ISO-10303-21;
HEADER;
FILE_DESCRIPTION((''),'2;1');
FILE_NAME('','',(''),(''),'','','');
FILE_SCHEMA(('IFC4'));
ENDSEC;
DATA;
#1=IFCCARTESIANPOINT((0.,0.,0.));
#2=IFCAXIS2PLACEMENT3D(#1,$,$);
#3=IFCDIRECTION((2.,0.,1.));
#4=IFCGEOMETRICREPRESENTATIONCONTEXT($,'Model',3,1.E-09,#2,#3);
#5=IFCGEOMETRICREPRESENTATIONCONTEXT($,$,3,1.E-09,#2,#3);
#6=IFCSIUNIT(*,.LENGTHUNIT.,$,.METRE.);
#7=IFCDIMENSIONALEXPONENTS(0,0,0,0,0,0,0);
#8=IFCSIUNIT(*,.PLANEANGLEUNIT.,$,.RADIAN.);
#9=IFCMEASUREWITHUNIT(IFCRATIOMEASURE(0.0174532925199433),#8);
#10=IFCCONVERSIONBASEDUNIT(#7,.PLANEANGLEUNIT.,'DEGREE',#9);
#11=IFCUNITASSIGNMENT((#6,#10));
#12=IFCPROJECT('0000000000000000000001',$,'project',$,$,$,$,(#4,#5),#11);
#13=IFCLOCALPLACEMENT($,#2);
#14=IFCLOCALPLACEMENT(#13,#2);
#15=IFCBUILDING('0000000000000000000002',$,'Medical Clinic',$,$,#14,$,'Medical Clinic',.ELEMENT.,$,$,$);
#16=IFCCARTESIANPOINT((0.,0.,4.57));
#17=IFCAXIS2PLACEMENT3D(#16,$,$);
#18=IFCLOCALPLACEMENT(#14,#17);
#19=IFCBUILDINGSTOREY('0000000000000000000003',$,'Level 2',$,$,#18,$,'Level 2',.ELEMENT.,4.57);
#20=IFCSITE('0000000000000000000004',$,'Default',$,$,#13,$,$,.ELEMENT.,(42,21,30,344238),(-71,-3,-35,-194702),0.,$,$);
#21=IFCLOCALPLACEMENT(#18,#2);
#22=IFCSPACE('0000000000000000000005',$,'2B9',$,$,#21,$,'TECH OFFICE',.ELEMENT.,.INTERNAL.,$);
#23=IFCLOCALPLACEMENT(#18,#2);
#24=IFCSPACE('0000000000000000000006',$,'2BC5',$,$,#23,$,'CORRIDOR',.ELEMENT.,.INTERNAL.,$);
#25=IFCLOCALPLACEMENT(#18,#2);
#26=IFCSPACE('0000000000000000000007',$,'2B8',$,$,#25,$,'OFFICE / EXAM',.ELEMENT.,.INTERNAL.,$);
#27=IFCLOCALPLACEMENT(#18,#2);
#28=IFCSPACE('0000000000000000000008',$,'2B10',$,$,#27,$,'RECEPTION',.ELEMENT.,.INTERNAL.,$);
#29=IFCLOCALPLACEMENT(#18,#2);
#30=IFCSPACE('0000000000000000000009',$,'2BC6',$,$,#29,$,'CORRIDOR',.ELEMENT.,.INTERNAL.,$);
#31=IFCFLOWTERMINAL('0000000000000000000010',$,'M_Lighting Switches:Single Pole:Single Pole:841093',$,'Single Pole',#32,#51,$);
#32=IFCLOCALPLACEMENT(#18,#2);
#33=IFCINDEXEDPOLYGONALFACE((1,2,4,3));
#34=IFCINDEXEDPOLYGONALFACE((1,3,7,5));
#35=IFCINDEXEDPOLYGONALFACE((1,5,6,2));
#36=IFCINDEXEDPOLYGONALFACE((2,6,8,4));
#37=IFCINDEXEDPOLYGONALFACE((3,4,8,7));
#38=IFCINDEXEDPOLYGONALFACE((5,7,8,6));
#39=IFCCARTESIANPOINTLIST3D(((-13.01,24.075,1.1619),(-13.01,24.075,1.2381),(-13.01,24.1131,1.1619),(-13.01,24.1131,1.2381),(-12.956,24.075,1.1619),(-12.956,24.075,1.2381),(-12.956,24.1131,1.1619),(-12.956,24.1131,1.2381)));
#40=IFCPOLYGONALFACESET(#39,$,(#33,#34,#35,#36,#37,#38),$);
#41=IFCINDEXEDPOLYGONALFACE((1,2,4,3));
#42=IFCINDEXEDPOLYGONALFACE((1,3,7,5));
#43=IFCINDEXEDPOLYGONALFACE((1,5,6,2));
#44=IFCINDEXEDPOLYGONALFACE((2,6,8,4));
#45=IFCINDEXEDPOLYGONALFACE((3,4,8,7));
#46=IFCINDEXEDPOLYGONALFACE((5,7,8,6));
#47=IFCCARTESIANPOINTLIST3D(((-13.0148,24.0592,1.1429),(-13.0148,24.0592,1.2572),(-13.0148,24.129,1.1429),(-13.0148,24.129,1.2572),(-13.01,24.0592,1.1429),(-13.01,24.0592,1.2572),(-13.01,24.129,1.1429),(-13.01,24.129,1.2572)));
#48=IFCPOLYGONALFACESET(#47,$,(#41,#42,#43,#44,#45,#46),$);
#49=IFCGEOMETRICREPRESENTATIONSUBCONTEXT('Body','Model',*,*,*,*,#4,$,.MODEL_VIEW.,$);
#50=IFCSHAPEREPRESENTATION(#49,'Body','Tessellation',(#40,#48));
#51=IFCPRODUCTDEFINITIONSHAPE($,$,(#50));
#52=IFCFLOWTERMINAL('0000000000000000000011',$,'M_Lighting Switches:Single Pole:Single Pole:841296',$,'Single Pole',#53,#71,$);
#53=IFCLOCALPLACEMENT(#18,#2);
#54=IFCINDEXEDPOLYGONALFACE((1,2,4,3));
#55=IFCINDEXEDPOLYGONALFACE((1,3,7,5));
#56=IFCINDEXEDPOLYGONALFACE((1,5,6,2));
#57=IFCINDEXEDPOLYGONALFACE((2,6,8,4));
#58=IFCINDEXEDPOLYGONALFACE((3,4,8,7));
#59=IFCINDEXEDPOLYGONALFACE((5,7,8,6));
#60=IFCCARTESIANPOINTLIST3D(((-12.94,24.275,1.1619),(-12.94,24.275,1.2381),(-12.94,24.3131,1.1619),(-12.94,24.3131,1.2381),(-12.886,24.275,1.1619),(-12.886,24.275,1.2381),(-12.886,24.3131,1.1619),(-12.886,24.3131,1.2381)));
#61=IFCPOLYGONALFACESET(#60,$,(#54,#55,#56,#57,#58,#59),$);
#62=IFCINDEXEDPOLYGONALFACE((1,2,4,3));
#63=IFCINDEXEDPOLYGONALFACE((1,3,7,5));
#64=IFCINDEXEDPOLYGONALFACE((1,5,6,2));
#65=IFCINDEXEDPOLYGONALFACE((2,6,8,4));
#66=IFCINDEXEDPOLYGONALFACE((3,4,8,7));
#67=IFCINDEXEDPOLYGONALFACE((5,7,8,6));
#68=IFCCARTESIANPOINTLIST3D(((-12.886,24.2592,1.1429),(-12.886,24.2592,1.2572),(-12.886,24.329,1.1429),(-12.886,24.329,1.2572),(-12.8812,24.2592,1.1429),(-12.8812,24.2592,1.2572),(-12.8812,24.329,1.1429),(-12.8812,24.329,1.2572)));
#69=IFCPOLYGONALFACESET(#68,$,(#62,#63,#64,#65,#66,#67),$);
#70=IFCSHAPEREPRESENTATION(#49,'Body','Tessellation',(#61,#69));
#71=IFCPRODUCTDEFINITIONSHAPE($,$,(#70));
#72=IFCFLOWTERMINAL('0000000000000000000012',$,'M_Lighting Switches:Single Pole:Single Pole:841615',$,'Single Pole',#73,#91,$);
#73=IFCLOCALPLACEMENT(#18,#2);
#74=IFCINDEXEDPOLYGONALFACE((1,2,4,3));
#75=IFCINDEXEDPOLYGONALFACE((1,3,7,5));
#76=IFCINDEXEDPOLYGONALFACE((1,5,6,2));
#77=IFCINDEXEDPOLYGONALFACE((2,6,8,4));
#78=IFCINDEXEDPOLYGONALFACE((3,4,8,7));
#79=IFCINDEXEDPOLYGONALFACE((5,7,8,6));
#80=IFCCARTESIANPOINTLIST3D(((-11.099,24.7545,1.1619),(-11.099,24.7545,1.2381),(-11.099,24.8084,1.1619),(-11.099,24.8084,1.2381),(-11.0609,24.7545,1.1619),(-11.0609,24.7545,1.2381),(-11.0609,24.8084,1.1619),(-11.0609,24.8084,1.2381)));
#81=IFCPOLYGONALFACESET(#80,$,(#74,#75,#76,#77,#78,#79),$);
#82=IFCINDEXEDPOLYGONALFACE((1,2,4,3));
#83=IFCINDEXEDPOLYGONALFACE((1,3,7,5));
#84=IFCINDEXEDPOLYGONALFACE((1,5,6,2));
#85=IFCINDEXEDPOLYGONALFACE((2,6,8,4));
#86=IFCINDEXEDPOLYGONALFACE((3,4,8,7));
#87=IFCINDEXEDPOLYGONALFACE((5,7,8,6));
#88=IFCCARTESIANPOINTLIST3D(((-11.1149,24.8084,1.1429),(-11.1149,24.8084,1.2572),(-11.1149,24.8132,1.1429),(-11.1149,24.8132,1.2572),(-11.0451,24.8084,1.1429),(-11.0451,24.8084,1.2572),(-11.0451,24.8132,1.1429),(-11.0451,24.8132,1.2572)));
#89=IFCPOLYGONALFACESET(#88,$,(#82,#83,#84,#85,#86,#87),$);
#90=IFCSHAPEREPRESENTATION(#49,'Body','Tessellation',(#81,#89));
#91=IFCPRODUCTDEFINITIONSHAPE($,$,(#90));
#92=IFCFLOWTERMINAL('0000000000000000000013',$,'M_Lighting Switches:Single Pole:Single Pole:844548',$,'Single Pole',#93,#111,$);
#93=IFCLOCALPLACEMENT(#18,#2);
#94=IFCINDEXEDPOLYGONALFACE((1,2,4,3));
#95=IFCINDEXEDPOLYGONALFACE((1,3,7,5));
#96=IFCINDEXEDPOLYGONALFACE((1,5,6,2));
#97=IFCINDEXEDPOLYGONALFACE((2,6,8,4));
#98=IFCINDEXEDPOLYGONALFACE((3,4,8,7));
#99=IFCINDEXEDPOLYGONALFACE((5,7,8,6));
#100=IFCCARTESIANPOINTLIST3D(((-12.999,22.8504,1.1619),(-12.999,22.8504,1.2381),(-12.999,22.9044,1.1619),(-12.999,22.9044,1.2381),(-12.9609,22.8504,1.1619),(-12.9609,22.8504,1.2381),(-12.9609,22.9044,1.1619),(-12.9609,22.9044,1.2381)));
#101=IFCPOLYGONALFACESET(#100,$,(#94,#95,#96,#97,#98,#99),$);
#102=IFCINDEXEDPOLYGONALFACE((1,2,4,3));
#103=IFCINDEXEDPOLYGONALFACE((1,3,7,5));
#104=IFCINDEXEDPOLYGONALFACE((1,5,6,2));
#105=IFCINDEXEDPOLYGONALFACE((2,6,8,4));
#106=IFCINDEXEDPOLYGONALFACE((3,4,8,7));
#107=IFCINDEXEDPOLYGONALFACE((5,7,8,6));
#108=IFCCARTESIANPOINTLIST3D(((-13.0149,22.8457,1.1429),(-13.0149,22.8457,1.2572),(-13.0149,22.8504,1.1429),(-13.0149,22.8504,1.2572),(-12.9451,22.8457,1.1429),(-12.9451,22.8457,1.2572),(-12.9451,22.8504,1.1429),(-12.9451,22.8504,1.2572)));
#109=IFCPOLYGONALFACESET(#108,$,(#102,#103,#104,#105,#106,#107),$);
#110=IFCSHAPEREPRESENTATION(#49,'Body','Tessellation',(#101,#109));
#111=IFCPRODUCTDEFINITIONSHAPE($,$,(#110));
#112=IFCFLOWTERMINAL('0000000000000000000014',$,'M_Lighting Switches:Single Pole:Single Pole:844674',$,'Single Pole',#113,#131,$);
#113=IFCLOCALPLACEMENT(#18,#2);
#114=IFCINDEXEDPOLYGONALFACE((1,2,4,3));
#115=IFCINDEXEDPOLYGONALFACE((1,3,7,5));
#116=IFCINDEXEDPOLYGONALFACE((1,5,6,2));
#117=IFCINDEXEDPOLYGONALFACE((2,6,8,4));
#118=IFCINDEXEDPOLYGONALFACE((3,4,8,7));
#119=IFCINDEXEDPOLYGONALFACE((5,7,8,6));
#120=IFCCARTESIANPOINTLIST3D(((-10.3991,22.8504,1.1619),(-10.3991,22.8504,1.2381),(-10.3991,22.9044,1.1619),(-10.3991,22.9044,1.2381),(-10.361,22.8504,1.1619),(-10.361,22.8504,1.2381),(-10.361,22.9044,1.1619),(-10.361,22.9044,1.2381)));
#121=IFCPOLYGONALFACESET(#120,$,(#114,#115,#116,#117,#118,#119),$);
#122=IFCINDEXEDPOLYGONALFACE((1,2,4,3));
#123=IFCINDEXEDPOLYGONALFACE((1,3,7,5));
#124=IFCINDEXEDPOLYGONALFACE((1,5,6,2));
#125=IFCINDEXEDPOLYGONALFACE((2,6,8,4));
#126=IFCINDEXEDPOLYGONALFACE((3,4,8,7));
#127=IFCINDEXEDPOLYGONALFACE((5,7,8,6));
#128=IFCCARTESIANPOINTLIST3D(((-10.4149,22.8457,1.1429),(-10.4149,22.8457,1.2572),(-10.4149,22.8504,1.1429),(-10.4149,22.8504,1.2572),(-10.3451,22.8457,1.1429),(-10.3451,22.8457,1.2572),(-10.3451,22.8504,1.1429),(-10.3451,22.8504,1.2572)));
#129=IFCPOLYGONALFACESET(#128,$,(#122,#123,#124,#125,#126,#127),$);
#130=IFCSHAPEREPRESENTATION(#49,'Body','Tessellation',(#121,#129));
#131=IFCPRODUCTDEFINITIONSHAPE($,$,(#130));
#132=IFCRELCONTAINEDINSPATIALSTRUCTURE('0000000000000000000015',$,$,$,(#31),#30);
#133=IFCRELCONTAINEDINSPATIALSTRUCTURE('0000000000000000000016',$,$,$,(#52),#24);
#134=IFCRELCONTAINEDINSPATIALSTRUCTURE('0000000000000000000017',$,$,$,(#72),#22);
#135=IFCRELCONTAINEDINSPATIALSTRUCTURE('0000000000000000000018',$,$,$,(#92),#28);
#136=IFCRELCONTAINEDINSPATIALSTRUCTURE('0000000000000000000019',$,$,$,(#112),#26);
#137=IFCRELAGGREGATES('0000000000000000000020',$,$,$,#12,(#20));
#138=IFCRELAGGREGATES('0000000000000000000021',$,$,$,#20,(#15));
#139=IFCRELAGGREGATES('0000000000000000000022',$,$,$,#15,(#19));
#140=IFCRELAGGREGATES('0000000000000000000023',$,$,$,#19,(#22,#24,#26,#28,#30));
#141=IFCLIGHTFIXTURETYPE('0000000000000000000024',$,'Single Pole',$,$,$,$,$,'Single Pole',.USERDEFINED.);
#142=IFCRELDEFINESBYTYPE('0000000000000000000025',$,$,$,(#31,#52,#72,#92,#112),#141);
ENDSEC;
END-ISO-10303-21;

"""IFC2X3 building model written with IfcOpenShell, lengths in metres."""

from ifc_helpers import new_model, entity, si_unit, converted_unit, direction, frame, frame_2d, origin, origin_2d_with_axis, place, context, subcontext, project, spatial, rectangle, extrude, source, transform, mapped, type_object, type_shapes, element, save


model = new_model("IFC2X3")

# Units and contexts
model_context = context("Model", 3, precision=1e-09, world=origin(), true_north=direction((2.0, 0.0, 1.0)))
context_of_model = context(None, 3, precision=1e-09, world=origin(), true_north=direction((2.0, 0.0, 1.0)))
body_context = subcontext(model_context, "Body", "Model", "MODEL_VIEW")
ifc_project = project(units=[si_unit("LENGTHUNIT", "METRE"), converted_unit("PLANEANGLEUNIT", "DEGREE", entity("IfcRatioMeasure", 0.0174532925199433), si_unit("PLANEANGLEUNIT", "RADIAN"), dimensions=[0, 0, 0, 0, 0, 0, 0])], contexts=[model_context, context_of_model])

# Site, building, storey, space
site_placement = place(None, origin())
site = spatial("IfcSite", under=ifc_project, at=site_placement, Name="Default", CompositionType="ELEMENT", RefLatitude=(42, 21, 30, 344238), RefLongitude=(-71, -3, -35, -194702), RefElevation=0.0)
building_placement = place(site_placement, origin())
building = spatial("IfcBuilding", under=site, at=building_placement, Name="Medical Clinic", LongName="Medical Clinic", CompositionType="ELEMENT")
storey_placement = place(building_placement, frame((0.0, 0.0, 4.57)))
storey = spatial("IfcBuildingStorey", under=building, at=storey_placement, Name="Level 2", LongName="Level 2", CompositionType="ELEMENT", Elevation=4.57)
space_1_placement = place(storey_placement, origin())
space_1 = spatial("IfcSpace", under=storey, at=space_1_placement, Name="2B9", LongName="TECH OFFICE", CompositionType="ELEMENT", InteriorOrExteriorSpace="INTERNAL")

# Shared definitions
space_2_placement = place(storey_placement, origin())
space_2 = spatial("IfcSpace", under=storey, at=space_2_placement, Name="2BC5", LongName="CORRIDOR", CompositionType="ELEMENT", InteriorOrExteriorSpace="INTERNAL")

# Shared definitions
space_3_placement = place(storey_placement, origin())
space_3 = spatial("IfcSpace", under=storey, at=space_3_placement, Name="2B8", LongName="OFFICE / EXAM", CompositionType="ELEMENT", InteriorOrExteriorSpace="INTERNAL")

# Shared definitions
space_4_placement = place(storey_placement, origin())
space_4 = spatial("IfcSpace", under=storey, at=space_4_placement, Name="2B10", LongName="RECEPTION", CompositionType="ELEMENT", InteriorOrExteriorSpace="INTERNAL")

# Shared definitions
space_5_placement = place(storey_placement, origin())
space_5 = spatial("IfcSpace", under=storey, at=space_5_placement, Name="2BC6", LongName="CORRIDOR", CompositionType="ELEMENT", InteriorOrExteriorSpace="INTERNAL")

# Flow terminals
light_fixture_type_1 = type_object("IfcLightFixtureType", Name="Single Pole", ElementType="Single Pole", PredefinedType="USERDEFINED")
shared_shape_1 = source(origin(), body_context, "Body", "SweptSolid", [
    extrude(rectangle(XDim=0.0381, YDim=0.0762, at=origin_2d_with_axis()), frame((0.0, 0.0, -0.054), z_axis=(0.0, 0.0, 1.0), x_axis=(-1.0, 0.0, 0.0)), (0.0, 0.0, 1.0), 0.054),
    extrude(rectangle(XDim=0.0698, YDim=0.1143, at=frame_2d((0.0, 0.0), x_axis=(1.0, 0.0))), frame((0.0, 0.0, 0.0), z_axis=(0.0, 0.0, 1.0), x_axis=(-1.0, 0.0, 0.0)), (0.0, 0.0, 1.0), 0.0048),
])
type_shapes(light_fixture_type_1, [shared_shape_1])
flow_terminal_1_placement = place(space_5_placement, frame((-13.01, 24.0941, 1.2), z_axis=(-1.0, 0.0, 0.0), x_axis=(0.0, -1.0, 0.0)))
element("IfcFlowTerminal", 1, at=flow_terminal_1_placement, inside=space_5, type_object=light_fixture_type_1, Name="M_Lighting Switches:Single Pole:Single Pole:841093", ObjectType="Single Pole", context=body_context, shape_type="MappedRepresentation", body=[
    mapped(shared_shape_1, transform((0.0, 0.0, 0.0), scale=1.0)),
])
flow_terminal_2_placement = place(space_2_placement, frame((-12.886, 24.2941, 1.2), z_axis=(1.0, 0.0, 0.0), x_axis=(0.0, 1.0, 0.0)))
element("IfcFlowTerminal", 2, at=flow_terminal_2_placement, inside=space_2, type_object=light_fixture_type_1, Name="M_Lighting Switches:Single Pole:Single Pole:841296", ObjectType="Single Pole", context=body_context, shape_type="MappedRepresentation", body=[
    mapped(shared_shape_1, transform((0.0, 0.0, 0.0), scale=1.0)),
])
flow_terminal_3_placement = place(space_1_placement, frame((-11.08, 24.8084, 1.2), z_axis=(0.0, 1.0, 0.0), x_axis=(-1.0, 0.0, 0.0)))
element("IfcFlowTerminal", 3, at=flow_terminal_3_placement, inside=space_1, type_object=light_fixture_type_1, Name="M_Lighting Switches:Single Pole:Single Pole:841615", ObjectType="Single Pole", context=body_context, shape_type="MappedRepresentation", body=[
    mapped(shared_shape_1, transform((0.0, 0.0, 0.0), scale=1.0)),
])
flow_terminal_4_placement = place(space_4_placement, frame((-12.98, 22.8504, 1.2), z_axis=(0.0, -1.0, 0.0), x_axis=(1.0, 0.0, 0.0)))
element("IfcFlowTerminal", 4, at=flow_terminal_4_placement, inside=space_4, type_object=light_fixture_type_1, Name="M_Lighting Switches:Single Pole:Single Pole:844548", ObjectType="Single Pole", context=body_context, shape_type="MappedRepresentation", body=[
    mapped(shared_shape_1, transform((0.0, 0.0, 0.0), scale=1.0)),
])
flow_terminal_5_placement = place(space_3_placement, frame((-10.38, 22.8504, 1.2), z_axis=(0.0, -1.0, 0.0), x_axis=(1.0, 0.0, 0.0)))
element("IfcFlowTerminal", 5, at=flow_terminal_5_placement, inside=space_3, type_object=light_fixture_type_1, Name="M_Lighting Switches:Single Pole:Single Pole:844674", ObjectType="Single Pole", context=body_context, shape_type="MappedRepresentation", body=[
    mapped(shared_shape_1, transform((0.0, 0.0, 0.0), scale=1.0)),
])

save(model, "model.ifc")
